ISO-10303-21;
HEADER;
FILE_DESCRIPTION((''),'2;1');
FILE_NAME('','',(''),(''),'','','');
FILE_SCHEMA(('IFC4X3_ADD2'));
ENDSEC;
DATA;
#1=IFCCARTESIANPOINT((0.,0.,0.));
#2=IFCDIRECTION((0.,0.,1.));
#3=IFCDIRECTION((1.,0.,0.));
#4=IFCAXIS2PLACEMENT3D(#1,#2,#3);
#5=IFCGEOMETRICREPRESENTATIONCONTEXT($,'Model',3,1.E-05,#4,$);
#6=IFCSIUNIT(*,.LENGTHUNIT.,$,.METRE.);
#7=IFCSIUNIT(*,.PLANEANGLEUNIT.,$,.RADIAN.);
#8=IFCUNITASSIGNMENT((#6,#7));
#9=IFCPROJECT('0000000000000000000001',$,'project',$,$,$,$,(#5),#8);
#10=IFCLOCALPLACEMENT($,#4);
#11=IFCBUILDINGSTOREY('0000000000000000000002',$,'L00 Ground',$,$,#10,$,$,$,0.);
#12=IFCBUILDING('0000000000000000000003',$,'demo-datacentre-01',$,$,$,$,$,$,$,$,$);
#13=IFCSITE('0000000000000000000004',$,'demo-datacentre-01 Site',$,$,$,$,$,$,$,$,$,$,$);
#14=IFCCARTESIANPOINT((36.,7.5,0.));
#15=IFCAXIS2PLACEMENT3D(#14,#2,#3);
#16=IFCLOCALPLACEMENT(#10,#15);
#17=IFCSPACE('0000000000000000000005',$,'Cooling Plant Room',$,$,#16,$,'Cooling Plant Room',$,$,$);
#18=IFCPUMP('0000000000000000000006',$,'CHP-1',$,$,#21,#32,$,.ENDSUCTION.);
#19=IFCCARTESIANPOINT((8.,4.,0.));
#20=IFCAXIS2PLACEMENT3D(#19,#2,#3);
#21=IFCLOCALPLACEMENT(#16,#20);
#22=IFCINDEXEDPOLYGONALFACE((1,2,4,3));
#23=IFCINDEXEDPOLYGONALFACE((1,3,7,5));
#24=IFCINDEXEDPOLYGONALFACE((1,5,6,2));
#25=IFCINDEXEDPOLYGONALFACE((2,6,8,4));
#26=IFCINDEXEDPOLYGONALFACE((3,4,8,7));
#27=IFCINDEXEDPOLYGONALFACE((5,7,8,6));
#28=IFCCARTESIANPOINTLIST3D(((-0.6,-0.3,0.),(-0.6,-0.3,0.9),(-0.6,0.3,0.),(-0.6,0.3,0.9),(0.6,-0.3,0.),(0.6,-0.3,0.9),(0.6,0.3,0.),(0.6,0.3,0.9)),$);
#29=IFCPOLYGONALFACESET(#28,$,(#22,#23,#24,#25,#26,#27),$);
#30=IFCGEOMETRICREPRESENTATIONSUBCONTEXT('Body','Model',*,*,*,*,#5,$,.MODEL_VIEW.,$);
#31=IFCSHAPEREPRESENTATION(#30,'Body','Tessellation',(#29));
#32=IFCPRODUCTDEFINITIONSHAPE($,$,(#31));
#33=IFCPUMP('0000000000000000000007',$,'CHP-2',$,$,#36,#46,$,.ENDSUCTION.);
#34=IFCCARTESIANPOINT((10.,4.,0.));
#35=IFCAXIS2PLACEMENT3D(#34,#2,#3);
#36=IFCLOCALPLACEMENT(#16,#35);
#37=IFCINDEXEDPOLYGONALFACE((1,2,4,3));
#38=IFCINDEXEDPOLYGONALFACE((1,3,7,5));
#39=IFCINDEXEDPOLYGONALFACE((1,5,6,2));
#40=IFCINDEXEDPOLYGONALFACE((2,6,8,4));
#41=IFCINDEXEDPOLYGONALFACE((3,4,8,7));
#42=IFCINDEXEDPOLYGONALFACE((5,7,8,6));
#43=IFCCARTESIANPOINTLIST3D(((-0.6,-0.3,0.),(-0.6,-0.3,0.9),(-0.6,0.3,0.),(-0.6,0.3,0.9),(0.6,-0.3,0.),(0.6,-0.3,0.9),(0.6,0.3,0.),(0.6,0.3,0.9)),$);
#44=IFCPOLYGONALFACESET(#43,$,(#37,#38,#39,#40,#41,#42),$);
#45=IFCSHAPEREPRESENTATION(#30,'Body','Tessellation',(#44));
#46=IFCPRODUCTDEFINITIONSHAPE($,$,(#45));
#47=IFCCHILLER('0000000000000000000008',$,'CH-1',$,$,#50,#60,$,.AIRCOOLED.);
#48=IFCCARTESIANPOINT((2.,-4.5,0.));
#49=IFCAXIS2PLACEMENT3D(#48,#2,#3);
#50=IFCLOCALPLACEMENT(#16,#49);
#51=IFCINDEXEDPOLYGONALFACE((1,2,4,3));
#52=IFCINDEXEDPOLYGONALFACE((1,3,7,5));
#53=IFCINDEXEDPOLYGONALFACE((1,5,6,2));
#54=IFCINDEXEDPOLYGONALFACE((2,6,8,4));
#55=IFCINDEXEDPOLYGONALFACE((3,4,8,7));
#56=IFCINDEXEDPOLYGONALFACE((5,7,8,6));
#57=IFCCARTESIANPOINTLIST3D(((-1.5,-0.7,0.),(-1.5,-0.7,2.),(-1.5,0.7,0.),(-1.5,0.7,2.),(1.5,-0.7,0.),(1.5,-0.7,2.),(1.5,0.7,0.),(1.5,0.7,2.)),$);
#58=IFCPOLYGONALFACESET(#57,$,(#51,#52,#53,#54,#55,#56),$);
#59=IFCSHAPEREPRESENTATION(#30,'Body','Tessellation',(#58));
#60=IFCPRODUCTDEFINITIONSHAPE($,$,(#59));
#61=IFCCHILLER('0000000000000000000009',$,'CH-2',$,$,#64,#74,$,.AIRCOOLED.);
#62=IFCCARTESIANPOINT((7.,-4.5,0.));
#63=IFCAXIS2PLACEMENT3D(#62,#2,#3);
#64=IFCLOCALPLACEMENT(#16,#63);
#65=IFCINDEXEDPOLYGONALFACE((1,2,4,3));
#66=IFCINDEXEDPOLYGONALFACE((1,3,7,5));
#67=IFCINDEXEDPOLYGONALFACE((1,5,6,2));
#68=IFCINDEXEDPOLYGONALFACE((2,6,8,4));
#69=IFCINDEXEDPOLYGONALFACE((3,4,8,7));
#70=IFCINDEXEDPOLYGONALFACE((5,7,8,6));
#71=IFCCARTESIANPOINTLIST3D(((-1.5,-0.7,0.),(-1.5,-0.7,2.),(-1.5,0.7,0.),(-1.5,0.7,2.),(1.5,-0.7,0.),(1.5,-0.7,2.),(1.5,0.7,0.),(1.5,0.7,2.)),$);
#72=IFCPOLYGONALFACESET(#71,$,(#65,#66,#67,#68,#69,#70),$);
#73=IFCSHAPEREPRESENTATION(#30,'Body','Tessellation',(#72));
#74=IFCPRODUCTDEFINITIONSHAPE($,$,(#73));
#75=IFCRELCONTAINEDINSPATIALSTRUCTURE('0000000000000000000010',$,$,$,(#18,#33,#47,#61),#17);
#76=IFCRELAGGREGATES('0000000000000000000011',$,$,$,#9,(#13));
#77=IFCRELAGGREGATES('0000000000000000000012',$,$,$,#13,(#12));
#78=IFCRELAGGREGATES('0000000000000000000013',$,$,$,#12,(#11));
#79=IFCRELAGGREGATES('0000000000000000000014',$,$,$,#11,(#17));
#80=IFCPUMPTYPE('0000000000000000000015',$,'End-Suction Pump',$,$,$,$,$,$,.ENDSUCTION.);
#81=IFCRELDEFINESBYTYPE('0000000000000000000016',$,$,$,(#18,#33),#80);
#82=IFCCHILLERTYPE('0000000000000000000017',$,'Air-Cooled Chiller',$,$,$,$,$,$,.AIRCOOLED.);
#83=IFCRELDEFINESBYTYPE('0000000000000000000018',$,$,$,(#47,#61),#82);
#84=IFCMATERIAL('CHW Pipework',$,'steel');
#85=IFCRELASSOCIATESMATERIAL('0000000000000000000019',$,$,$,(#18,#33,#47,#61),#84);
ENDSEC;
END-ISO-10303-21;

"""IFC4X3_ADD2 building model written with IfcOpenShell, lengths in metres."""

from ifc_helpers import new_model, si_unit, frame, origin_with_axes, place, context, subcontext, project, spatial, rectangle, extrude, material, type_object, element, save


model = new_model("IFC4X3_ADD2")

# Units and contexts
model_context = context("Model", 3, precision=1e-05, world=origin_with_axes())
body_context = subcontext(model_context, "Body", "Model", "MODEL_VIEW")
ifc_project = project(units=[si_unit("LENGTHUNIT", "METRE"), si_unit("PLANEANGLEUNIT", "RADIAN")], contexts=[model_context])

# Site, building, storey
site = spatial("IfcSite", under=ifc_project, Name="demo-datacentre-01 Site")
building = spatial("IfcBuilding", under=site, Name="demo-datacentre-01")
storey_placement = place(None, origin_with_axes())
storey = spatial("IfcBuildingStorey", under=building, at=storey_placement, Name="L00 Ground", Elevation=0.0)

# Shared definitions
ifc_material = material(Name="CHW Pipework", Category="steel")

# Shared definitions
space_placement = place(storey_placement, frame((36.0, 7.5, 0.0), z_axis=(0.0, 0.0, 1.0), x_axis=(1.0, 0.0, 0.0)))
space = spatial("IfcSpace", under=storey, at=space_placement, Name="Cooling Plant Room", LongName="Cooling Plant Room")

# Pumps
pump_type = type_object("IfcPumpType", Name="End-Suction Pump", PredefinedType="ENDSUCTION")
for number, where, z_axis, x_axis, name in (
    (1, (8.0, 4.0, 0.0), (0.0, 0.0, 1.0), (1.0, 0.0, 0.0), "CHP-1"),
    (2, (10.0, 4.0, 0.0), (0.0, 0.0, 1.0), (1.0, 0.0, 0.0), "CHP-2"),
):
    element("IfcPump", number, at=place(space_placement, frame(where, z_axis=z_axis, x_axis=x_axis)), inside=space, type_object=pump_type, material=ifc_material, Name=name, PredefinedType="ENDSUCTION", context=body_context, shape_type="SweptSolid", body=[
        extrude(rectangle(XDim=1.2, YDim=0.6), origin_with_axes(), (0.0, 0.0, 1.0), 0.9),
    ])

# Chillers
chiller_type = type_object("IfcChillerType", Name="Air-Cooled Chiller", PredefinedType="AIRCOOLED")
for number, where, z_axis, x_axis, name in (
    (3, (2.0, -4.5, 0.0), (0.0, 0.0, 1.0), (1.0, 0.0, 0.0), "CH-1"),
    (4, (7.0, -4.5, 0.0), (0.0, 0.0, 1.0), (1.0, 0.0, 0.0), "CH-2"),
):
    element("IfcChiller", number, at=place(space_placement, frame(where, z_axis=z_axis, x_axis=x_axis)), inside=space, type_object=chiller_type, material=ifc_material, Name=name, PredefinedType="AIRCOOLED", context=body_context, shape_type="SweptSolid", body=[
        extrude(rectangle(XDim=3.0, YDim=1.4), origin_with_axes(), (0.0, 0.0, 1.0), 2.0),
    ])

save(model, "model.ifc")
